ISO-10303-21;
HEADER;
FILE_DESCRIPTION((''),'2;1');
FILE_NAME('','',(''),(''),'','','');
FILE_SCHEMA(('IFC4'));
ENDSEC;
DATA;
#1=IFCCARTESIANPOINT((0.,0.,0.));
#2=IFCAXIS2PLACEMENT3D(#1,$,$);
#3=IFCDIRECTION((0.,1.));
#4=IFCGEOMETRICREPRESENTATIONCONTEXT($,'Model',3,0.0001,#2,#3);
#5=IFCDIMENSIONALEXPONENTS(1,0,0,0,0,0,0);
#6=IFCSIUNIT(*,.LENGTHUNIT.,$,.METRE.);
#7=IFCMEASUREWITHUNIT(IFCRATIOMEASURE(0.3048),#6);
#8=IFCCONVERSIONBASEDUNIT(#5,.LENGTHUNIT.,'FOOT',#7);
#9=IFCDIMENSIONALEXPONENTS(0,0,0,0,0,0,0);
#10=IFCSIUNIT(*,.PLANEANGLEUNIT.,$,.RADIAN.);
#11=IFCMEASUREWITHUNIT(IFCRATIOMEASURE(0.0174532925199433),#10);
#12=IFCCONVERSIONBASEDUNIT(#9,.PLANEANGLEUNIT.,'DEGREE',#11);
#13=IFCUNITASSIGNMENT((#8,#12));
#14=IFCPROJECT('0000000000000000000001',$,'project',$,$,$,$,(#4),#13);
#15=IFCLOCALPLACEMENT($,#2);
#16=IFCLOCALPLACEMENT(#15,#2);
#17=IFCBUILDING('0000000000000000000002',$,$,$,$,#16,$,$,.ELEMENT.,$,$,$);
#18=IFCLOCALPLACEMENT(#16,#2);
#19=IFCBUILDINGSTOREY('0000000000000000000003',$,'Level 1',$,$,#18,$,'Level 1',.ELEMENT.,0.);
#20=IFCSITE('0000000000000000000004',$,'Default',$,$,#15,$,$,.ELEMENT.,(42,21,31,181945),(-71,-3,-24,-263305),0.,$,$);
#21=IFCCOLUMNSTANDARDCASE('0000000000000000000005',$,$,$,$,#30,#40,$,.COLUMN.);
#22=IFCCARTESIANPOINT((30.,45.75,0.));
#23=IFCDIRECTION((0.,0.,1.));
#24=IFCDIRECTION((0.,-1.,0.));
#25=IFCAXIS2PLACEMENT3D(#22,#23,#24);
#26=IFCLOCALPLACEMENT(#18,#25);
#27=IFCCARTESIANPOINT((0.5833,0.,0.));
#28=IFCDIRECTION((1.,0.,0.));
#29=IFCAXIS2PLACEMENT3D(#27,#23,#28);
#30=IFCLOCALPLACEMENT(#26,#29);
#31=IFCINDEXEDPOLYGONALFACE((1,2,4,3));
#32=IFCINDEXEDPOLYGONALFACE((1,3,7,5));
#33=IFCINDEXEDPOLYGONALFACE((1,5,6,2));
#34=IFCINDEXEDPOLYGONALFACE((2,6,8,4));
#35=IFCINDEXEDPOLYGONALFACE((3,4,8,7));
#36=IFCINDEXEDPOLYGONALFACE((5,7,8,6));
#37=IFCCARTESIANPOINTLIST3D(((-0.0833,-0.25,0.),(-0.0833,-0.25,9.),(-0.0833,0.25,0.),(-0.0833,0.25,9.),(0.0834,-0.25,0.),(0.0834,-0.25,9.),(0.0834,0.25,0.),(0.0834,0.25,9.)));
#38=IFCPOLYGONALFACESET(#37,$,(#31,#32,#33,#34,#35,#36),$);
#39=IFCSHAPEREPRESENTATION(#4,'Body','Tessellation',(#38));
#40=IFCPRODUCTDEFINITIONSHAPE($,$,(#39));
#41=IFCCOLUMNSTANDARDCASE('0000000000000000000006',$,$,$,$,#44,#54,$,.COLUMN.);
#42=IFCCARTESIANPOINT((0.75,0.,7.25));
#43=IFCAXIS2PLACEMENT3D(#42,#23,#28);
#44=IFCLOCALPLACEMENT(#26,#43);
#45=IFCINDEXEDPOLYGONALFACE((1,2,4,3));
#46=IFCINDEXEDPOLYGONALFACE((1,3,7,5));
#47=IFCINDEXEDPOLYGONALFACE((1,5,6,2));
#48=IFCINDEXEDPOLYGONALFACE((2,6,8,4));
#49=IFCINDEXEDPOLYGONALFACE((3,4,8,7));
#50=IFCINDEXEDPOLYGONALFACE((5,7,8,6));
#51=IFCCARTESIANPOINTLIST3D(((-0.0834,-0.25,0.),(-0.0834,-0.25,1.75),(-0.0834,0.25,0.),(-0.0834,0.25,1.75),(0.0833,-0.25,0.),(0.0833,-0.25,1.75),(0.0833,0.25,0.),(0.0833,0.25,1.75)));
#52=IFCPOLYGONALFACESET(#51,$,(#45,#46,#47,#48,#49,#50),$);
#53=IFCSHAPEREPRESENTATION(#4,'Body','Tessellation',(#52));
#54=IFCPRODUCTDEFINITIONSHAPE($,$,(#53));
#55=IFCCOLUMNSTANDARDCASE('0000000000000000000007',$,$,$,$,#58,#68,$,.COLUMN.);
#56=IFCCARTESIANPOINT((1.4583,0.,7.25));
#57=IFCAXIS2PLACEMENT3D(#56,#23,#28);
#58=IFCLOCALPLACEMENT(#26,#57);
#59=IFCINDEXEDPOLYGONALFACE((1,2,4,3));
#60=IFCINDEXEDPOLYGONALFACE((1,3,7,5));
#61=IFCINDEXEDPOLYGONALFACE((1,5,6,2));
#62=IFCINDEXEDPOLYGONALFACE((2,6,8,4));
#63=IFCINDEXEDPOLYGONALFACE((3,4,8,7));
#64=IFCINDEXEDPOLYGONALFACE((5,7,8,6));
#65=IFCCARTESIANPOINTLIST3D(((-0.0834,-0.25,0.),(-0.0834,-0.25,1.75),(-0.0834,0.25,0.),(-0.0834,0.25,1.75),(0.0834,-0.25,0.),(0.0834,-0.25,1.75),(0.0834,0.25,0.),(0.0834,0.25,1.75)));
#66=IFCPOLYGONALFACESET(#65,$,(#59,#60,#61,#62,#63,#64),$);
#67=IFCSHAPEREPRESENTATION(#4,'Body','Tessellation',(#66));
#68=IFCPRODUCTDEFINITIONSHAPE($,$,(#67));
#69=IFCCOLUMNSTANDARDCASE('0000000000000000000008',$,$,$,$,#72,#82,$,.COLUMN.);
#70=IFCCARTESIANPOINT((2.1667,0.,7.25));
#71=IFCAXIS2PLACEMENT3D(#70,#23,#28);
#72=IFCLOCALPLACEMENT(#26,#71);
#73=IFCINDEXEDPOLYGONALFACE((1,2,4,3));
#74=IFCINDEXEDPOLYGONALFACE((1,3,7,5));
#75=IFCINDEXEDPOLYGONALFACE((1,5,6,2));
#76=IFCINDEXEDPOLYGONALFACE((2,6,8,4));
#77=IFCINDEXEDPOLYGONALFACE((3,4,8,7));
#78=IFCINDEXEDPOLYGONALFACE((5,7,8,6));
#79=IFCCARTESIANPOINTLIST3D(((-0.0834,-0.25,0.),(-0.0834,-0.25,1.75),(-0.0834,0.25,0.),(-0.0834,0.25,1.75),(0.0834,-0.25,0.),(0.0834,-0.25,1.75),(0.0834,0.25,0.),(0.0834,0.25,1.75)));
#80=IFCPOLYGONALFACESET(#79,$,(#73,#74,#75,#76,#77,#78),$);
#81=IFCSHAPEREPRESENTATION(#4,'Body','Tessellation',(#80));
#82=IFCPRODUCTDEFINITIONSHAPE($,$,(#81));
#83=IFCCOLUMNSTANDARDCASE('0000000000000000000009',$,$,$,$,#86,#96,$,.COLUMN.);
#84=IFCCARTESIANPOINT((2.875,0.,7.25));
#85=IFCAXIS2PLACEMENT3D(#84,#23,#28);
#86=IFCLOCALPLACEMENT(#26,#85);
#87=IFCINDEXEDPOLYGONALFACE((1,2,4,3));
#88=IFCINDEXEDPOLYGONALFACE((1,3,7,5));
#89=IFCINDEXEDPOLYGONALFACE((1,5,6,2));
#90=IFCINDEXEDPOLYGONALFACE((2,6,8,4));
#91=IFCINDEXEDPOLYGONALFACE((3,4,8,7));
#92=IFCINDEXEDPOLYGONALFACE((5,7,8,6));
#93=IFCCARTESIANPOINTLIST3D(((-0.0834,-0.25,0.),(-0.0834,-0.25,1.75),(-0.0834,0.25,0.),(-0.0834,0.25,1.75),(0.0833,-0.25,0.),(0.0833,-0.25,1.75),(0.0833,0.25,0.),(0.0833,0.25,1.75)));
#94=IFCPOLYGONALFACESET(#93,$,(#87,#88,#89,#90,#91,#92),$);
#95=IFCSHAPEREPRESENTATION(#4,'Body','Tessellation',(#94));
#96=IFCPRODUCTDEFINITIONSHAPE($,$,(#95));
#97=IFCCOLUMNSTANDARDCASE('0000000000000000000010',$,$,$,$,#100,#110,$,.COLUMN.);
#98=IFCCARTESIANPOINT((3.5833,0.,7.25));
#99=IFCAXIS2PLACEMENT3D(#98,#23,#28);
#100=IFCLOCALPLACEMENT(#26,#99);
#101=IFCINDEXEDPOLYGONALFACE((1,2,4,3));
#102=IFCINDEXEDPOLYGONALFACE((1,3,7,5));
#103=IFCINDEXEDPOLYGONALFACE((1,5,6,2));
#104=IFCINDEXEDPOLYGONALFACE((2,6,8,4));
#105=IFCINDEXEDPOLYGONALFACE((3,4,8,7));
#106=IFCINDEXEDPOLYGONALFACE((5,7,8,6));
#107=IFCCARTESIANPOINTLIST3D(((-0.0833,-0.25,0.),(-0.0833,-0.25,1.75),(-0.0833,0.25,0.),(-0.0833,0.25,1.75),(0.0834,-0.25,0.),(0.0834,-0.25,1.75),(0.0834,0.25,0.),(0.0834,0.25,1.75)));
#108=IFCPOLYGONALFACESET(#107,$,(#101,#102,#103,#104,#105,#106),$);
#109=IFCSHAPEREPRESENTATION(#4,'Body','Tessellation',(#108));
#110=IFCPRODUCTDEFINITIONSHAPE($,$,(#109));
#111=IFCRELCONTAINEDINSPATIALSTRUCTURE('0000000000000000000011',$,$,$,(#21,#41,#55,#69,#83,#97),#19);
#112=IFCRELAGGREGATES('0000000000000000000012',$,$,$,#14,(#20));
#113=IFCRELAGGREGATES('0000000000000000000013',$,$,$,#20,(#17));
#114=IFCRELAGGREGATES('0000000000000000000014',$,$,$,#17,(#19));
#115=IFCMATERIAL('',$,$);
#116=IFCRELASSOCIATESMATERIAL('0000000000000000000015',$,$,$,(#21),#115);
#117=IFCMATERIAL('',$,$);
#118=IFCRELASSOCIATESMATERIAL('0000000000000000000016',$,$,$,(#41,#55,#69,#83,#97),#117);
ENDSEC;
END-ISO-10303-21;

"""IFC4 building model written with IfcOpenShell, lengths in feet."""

from ifc_helpers import new_model, entity, si_unit, converted_unit, direction, frame, origin, place, context, project, spatial, rectangle, extrude, material, element, save


model = new_model("IFC4")

# Units and contexts
model_context = context("Model", 3, precision=0.0001, world=origin(), true_north=direction((0.0, 1.0)))
ifc_project = project(units=[converted_unit("LENGTHUNIT", "FOOT", entity("IfcRatioMeasure", 0.3048), si_unit("LENGTHUNIT", "METRE"), dimensions=[1, 0, 0, 0, 0, 0, 0]), converted_unit("PLANEANGLEUNIT", "DEGREE", entity("IfcRatioMeasure", 0.0174532925199433), si_unit("PLANEANGLEUNIT", "RADIAN"), dimensions=[0, 0, 0, 0, 0, 0, 0])], contexts=[model_context])

# Site, building, storey
site_placement = place(None, origin())
site = spatial("IfcSite", under=ifc_project, at=site_placement, Name="Default", CompositionType="ELEMENT", RefLatitude=(42, 21, 31, 181945), RefLongitude=(-71, -3, -24, -263305), RefElevation=0.0)
building_placement = place(site_placement, origin())
building = spatial("IfcBuilding", under=site, at=building_placement, CompositionType="ELEMENT")
storey_placement = place(building_placement, origin())
storey = spatial("IfcBuildingStorey", under=building, at=storey_placement, Name="Level 1", LongName="Level 1", CompositionType="ELEMENT", Elevation=0.0)

# Columns
ifc_material_1 = material(Name="")
ifc_material_2 = material(Name="")
wall_placement = place(storey_placement, frame((30.0, 45.75, 0.0), z_axis=(0.0, 0.0, 1.0), x_axis=(0.0, -1.0, 0.0)))
for number, where, z_axis, x_axis in (
    (1, (0.5833, 0.0, 0.0), (0.0, 0.0, 1.0), (1.0, 0.0, 0.0)),
):
    element("IfcColumnStandardCase", number, at=place(wall_placement, frame(where, z_axis=z_axis, x_axis=x_axis)), inside=storey, material=ifc_material_2, PredefinedType="COLUMN", context=model_context, shape_type="SweptSolid", body=[
        extrude(rectangle(XDim=0.1667, YDim=0.5), origin(), (0.0, 0.0, 1.0), 9.0),
    ])
for number, where, z_axis, x_axis in (
    (2, (0.75, 0.0, 7.25), (0.0, 0.0, 1.0), (1.0, 0.0, 0.0)),
    (3, (1.4583, 0.0, 7.25), (0.0, 0.0, 1.0), (1.0, 0.0, 0.0)),
    (4, (2.1667, 0.0, 7.25), (0.0, 0.0, 1.0), (1.0, 0.0, 0.0)),
    (5, (2.875, 0.0, 7.25), (0.0, 0.0, 1.0), (1.0, 0.0, 0.0)),
    (6, (3.5833, 0.0, 7.25), (0.0, 0.0, 1.0), (1.0, 0.0, 0.0)),
):
    element("IfcColumnStandardCase", number, at=place(wall_placement, frame(where, z_axis=z_axis, x_axis=x_axis)), inside=storey, material=ifc_material_1, PredefinedType="COLUMN", context=model_context, shape_type="SweptSolid", body=[
        extrude(rectangle(XDim=0.1667, YDim=0.5), origin(), (0.0, 0.0, 1.0), 1.75),
    ])

save(model, "model.ifc")
